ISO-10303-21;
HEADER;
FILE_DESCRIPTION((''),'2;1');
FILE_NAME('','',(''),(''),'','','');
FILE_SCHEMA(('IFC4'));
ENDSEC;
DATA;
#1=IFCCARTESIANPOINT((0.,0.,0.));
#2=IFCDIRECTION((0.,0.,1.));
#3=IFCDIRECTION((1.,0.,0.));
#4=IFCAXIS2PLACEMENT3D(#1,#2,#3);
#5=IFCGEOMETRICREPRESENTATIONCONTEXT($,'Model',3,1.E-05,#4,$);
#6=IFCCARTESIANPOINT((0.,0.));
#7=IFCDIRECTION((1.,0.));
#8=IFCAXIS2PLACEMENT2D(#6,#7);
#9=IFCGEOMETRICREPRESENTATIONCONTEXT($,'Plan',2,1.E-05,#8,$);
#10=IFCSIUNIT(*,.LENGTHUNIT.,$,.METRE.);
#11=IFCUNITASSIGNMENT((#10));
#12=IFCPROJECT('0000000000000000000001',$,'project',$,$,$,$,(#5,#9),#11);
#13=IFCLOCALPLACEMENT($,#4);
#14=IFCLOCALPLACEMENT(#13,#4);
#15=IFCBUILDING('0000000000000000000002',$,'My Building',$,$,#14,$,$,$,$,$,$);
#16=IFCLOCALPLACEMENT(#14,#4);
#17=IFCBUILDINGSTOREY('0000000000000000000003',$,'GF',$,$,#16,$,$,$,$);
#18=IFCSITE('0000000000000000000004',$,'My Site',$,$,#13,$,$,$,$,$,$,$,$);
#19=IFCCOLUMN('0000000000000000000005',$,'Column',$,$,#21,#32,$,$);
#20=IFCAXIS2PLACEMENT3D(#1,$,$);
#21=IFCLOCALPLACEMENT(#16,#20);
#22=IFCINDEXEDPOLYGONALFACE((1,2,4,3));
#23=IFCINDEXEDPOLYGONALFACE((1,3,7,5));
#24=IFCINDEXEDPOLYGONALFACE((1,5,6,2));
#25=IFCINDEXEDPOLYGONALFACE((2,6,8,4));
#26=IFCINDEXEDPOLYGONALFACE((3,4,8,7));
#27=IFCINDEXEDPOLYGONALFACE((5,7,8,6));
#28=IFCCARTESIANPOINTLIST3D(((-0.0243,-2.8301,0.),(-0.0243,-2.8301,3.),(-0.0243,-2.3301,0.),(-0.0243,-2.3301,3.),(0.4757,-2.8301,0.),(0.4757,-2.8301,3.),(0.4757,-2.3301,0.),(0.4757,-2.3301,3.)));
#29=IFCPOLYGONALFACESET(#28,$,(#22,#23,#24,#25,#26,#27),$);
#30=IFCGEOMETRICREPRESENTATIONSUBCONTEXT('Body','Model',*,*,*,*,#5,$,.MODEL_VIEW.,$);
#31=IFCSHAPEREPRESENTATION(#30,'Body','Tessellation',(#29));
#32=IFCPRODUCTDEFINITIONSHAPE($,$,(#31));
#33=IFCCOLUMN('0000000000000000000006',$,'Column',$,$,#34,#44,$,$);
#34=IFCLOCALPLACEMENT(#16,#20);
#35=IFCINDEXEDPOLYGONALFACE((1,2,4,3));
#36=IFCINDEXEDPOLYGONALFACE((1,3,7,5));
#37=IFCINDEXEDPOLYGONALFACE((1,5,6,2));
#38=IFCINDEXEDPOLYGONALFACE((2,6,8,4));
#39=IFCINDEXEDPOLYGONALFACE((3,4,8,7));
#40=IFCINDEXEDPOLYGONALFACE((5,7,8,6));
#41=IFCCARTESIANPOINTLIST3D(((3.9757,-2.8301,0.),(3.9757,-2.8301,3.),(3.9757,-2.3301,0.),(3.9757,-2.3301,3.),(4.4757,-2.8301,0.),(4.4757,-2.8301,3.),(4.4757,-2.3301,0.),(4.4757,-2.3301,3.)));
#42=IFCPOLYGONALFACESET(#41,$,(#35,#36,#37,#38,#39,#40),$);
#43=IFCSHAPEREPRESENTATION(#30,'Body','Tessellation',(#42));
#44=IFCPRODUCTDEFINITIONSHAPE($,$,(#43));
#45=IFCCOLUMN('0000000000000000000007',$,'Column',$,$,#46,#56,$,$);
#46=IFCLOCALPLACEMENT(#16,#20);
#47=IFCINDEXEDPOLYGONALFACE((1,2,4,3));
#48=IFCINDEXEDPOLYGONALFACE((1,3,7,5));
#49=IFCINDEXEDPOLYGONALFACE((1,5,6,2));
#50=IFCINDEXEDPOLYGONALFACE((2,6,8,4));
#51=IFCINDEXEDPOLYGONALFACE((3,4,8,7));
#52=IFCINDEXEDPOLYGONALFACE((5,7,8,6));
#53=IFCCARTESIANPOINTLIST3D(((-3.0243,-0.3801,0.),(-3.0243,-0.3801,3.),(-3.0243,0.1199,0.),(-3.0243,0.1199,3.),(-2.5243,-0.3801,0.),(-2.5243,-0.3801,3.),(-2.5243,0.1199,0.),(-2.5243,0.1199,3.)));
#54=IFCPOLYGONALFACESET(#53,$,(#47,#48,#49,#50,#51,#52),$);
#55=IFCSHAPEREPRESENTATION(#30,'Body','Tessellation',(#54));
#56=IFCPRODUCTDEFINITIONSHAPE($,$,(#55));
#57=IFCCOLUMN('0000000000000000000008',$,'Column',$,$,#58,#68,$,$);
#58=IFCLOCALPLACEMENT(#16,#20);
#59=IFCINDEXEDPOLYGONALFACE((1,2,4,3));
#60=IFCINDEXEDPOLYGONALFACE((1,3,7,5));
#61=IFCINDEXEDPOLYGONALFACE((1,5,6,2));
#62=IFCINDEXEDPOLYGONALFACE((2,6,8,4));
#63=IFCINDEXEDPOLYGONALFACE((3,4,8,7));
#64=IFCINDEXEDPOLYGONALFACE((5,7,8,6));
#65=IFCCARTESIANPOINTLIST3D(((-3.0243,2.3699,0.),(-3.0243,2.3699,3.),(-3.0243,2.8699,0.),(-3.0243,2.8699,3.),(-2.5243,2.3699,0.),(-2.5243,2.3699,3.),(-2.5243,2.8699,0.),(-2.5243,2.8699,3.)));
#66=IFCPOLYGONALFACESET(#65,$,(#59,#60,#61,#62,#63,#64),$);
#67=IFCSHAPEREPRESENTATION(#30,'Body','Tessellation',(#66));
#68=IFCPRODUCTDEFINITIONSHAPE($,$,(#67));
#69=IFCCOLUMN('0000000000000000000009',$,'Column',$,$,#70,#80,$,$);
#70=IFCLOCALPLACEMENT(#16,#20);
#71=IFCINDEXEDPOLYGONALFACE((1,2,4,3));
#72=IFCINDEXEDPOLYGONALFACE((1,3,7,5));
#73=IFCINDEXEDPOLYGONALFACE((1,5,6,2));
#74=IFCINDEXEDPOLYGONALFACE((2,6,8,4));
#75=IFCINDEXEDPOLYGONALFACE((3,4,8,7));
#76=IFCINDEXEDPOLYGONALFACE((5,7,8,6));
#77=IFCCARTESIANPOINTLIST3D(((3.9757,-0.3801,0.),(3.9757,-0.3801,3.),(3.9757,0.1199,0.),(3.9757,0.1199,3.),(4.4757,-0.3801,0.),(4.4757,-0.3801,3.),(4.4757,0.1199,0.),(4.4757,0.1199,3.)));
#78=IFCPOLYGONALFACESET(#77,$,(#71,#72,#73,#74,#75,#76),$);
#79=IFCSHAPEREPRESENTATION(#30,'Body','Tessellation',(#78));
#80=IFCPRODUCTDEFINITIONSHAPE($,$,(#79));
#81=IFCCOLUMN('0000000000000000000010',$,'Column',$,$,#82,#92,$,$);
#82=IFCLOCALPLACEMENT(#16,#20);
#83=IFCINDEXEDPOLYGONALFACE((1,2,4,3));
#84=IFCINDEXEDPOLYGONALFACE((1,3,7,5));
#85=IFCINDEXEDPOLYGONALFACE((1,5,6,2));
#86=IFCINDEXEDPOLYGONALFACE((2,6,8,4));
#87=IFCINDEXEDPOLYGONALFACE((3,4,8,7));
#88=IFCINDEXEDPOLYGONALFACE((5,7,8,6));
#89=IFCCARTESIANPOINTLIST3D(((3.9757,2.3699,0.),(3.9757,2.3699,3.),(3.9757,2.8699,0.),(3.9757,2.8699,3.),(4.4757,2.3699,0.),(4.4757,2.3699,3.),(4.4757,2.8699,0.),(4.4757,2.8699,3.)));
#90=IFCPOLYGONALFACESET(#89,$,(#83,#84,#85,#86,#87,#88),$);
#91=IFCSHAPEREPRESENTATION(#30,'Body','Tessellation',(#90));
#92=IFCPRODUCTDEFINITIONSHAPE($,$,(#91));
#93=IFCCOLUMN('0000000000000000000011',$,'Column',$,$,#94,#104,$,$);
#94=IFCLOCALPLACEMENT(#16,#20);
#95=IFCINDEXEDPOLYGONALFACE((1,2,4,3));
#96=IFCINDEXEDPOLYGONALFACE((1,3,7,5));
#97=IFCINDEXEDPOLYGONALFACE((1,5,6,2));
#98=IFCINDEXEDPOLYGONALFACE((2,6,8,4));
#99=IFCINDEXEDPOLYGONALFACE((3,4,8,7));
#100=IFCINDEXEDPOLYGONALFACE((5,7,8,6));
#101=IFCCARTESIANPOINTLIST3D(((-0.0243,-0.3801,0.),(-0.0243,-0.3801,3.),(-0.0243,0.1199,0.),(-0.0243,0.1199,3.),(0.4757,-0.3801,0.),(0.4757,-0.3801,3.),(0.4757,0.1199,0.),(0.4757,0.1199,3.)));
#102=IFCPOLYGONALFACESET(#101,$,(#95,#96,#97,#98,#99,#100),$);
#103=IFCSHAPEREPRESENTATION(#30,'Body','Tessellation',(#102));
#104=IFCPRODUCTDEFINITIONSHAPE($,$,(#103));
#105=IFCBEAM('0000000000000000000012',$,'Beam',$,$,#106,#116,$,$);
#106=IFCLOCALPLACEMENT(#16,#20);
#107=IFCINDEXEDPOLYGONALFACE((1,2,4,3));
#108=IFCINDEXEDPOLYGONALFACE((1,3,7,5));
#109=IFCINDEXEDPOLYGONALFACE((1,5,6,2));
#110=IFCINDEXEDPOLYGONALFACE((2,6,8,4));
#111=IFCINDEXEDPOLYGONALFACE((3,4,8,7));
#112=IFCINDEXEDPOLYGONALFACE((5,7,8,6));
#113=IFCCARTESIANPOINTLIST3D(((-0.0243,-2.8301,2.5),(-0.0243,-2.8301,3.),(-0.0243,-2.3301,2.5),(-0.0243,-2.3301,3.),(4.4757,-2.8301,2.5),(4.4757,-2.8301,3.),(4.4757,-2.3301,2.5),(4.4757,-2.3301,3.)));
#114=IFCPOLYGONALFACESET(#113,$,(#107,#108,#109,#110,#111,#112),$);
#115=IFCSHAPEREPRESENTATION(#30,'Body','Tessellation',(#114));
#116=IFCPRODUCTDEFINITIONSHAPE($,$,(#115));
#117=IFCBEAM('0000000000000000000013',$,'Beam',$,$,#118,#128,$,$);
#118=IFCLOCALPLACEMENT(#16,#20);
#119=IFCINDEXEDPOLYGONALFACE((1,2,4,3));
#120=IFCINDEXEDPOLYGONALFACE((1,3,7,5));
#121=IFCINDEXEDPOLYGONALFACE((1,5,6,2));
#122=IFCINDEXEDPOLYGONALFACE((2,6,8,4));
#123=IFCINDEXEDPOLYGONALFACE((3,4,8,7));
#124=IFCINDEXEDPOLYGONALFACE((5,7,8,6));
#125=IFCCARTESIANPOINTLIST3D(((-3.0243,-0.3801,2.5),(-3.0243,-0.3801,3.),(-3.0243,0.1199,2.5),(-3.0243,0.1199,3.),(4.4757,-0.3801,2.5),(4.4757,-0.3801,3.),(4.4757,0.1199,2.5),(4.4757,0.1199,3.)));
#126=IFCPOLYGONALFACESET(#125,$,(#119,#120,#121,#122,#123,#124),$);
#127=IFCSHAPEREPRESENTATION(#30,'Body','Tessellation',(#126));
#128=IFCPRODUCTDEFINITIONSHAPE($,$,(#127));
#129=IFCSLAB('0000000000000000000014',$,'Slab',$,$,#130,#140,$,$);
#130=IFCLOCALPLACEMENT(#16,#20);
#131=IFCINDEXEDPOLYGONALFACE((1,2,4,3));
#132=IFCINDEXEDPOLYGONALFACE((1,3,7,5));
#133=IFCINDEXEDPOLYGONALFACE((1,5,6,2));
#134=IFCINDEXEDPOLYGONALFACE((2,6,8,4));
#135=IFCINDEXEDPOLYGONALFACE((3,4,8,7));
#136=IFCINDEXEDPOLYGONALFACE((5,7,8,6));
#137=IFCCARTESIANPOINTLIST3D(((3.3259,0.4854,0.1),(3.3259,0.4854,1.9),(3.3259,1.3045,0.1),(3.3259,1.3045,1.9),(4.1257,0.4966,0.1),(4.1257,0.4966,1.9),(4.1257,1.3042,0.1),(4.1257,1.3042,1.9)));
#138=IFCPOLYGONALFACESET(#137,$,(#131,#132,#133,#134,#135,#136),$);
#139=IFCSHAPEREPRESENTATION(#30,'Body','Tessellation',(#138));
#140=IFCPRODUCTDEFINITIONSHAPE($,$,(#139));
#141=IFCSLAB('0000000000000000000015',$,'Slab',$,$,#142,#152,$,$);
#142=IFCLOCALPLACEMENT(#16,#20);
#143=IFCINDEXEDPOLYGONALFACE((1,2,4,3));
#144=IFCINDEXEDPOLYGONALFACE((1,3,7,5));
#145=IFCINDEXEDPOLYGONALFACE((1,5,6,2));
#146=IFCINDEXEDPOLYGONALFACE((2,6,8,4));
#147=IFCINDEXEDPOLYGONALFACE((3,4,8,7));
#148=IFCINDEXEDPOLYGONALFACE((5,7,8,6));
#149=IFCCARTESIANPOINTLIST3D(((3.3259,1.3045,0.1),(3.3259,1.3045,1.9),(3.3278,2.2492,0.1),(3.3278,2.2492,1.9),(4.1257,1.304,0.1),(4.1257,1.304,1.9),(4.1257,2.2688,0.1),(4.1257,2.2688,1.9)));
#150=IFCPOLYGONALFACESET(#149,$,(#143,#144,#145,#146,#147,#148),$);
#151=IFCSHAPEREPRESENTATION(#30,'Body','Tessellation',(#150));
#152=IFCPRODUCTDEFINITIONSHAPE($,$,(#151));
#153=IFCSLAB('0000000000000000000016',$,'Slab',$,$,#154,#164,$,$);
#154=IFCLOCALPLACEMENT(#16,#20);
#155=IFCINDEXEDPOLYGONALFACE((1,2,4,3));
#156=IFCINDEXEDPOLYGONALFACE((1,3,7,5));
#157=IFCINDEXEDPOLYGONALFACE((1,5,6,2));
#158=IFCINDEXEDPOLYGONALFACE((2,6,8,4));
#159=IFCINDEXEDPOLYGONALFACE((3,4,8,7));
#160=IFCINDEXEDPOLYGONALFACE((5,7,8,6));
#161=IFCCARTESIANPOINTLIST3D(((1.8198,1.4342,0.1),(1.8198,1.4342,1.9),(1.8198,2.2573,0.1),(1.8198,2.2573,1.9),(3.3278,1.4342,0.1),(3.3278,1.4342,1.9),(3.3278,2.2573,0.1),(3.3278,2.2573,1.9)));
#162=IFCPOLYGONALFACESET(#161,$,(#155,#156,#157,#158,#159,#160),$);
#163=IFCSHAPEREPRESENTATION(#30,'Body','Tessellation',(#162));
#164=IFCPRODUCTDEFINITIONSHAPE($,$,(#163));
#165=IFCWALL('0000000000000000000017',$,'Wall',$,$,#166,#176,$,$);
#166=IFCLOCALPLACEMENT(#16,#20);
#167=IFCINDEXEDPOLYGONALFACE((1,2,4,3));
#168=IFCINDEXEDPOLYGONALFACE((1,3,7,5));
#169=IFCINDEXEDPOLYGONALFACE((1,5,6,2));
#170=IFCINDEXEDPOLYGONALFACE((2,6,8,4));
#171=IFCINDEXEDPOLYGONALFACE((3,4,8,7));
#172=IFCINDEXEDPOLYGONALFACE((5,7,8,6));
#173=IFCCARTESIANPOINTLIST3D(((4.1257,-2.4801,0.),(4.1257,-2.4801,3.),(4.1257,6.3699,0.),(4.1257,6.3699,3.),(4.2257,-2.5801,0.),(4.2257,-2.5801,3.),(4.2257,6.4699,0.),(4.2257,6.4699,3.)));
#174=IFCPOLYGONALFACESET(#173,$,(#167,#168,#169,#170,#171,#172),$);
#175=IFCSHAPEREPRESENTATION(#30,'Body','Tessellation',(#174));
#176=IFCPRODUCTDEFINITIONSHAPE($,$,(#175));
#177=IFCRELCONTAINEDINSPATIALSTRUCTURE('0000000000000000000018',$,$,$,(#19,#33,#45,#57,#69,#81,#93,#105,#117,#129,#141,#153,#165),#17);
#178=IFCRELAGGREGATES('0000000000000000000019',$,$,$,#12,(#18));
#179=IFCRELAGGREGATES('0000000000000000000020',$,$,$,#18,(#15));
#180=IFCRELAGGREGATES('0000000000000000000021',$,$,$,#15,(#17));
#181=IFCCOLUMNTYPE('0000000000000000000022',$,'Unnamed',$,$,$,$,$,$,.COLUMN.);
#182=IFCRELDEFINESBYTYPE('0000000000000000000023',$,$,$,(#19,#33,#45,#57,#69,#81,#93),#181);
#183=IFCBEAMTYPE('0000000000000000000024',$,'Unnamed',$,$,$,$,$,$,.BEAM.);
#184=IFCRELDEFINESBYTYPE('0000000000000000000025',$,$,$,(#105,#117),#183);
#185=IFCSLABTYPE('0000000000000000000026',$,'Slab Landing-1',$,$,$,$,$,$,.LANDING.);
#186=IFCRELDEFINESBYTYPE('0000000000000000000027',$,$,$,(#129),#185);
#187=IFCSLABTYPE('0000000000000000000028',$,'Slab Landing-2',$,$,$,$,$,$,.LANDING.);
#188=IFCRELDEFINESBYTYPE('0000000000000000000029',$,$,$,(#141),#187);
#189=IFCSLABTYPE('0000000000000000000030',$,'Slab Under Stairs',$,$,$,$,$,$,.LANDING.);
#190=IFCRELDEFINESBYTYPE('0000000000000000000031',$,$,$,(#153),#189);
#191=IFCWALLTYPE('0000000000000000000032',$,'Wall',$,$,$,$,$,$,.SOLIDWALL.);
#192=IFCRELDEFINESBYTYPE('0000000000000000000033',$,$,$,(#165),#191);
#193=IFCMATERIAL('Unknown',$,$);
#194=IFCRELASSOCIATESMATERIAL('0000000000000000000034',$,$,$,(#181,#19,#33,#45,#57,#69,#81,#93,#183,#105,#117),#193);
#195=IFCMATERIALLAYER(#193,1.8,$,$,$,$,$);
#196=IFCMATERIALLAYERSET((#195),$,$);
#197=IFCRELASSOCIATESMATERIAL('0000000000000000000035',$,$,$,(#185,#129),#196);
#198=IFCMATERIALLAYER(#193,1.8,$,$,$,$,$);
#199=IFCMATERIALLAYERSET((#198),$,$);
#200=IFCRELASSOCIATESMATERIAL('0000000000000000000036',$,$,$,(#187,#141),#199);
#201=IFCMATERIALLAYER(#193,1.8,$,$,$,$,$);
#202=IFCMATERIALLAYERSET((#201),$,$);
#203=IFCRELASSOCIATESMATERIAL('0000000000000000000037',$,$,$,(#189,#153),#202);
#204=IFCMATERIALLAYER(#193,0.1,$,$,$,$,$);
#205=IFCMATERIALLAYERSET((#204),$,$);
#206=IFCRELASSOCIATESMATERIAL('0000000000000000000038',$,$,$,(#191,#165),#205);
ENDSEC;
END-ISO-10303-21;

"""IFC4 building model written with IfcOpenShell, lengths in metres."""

from ifc_helpers import new_model, si_unit, frame, origin_with_axes, origin_2d_with_axis, place, context, subcontext, project, spatial, line, indexed_curve, rectangle, outline, extrude, material, layer, layer_set, layer_usage, material_profile, profile_set, profile_usage, type_object, element, save


model = new_model("IFC4")

# Units and contexts
model_context = context("Model", 3, precision=1e-05, world=origin_with_axes())
plan_context = context("Plan", 2, precision=1e-05, world=origin_2d_with_axis())
body_context_1 = subcontext(model_context, "Body", "Model", "MODEL_VIEW")
ifc_project = project(units=[si_unit("LENGTHUNIT", "METRE")], contexts=[model_context, plan_context])

# Site, building, storey
site_placement = place(None, origin_with_axes())
site = spatial("IfcSite", under=ifc_project, at=site_placement, Name="My Site")
building_placement = place(site_placement, origin_with_axes())
building = spatial("IfcBuilding", under=site, at=building_placement, Name="My Building")
storey_placement = place(building_placement, origin_with_axes())
storey = spatial("IfcBuildingStorey", under=building, at=storey_placement, Name="GF")

# Columns
ifc_material = material(Name="Unknown")
ifc_material_profile_1 = material_profile(ifc_material, rectangle(XDim=0.5, YDim=0.5))
ifc_profile_set_1 = profile_set([ifc_material_profile_1])
ifc_profile_usage_1 = profile_usage(ifc_profile_set_1, cardinal=5)
column_type = type_object("IfcColumnType", Name="Unnamed", PredefinedType="COLUMN", material=ifc_profile_set_1)
column_1_placement = place(storey_placement, frame((0.2257, -2.5801, 0.0), z_axis=(0.0, 0.0, 1.0), x_axis=(1.0, 0.0, 0.0)))
element("IfcColumn", 1, at=column_1_placement, inside=storey, type_object=column_type, material=ifc_profile_usage_1, Name="Column", context=body_context_1, shape_type="SweptSolid", body=[
    extrude(rectangle(XDim=0.5, YDim=0.5), origin_with_axes(), (0.0, 0.0, 1.0), 3.0),
])
ifc_profile_usage_2 = profile_usage(ifc_profile_set_1, cardinal=5)
column_2_placement = place(storey_placement, frame((4.2257, -2.5801, 0.0), z_axis=(0.0, 0.0, 1.0), x_axis=(1.0, 0.0, 0.0)))
element("IfcColumn", 2, at=column_2_placement, inside=storey, type_object=column_type, material=ifc_profile_usage_2, Name="Column", context=body_context_1, shape_type="SweptSolid", body=[
    extrude(rectangle(XDim=0.5, YDim=0.5), origin_with_axes(), (0.0, 0.0, 1.0), 3.0),
])
ifc_profile_usage_3 = profile_usage(ifc_profile_set_1, cardinal=5)
column_3_placement = place(storey_placement, frame((-2.7743, -0.1301, 0.0), z_axis=(0.0, 0.0, 1.0), x_axis=(1.0, 0.0, 0.0)))
element("IfcColumn", 3, at=column_3_placement, inside=storey, type_object=column_type, material=ifc_profile_usage_3, Name="Column", context=body_context_1, shape_type="SweptSolid", body=[
    extrude(rectangle(XDim=0.5, YDim=0.5), origin_with_axes(), (0.0, 0.0, 1.0), 3.0),
])
ifc_profile_usage_4 = profile_usage(ifc_profile_set_1, cardinal=5)
column_4_placement = place(storey_placement, frame((-2.7743, 2.6199, 0.0), z_axis=(0.0, 0.0, 1.0), x_axis=(1.0, 0.0, 0.0)))
element("IfcColumn", 4, at=column_4_placement, inside=storey, type_object=column_type, material=ifc_profile_usage_4, Name="Column", context=body_context_1, shape_type="SweptSolid", body=[
    extrude(rectangle(XDim=0.5, YDim=0.5), origin_with_axes(), (0.0, 0.0, 1.0), 3.0),
])
ifc_profile_usage_5 = profile_usage(ifc_profile_set_1, cardinal=5)
column_5_placement = place(storey_placement, frame((4.2257, -0.1301, 0.0), z_axis=(0.0, 0.0, 1.0), x_axis=(1.0, 0.0, 0.0)))
element("IfcColumn", 5, at=column_5_placement, inside=storey, type_object=column_type, material=ifc_profile_usage_5, Name="Column", context=body_context_1, shape_type="SweptSolid", body=[
    extrude(rectangle(XDim=0.5, YDim=0.5), origin_with_axes(), (0.0, 0.0, 1.0), 3.0),
])
ifc_profile_usage_6 = profile_usage(ifc_profile_set_1, cardinal=5)
column_6_placement = place(storey_placement, frame((4.2257, 2.6199, 0.0), z_axis=(0.0, 0.0, 1.0), x_axis=(1.0, 0.0, 0.0)))
element("IfcColumn", 6, at=column_6_placement, inside=storey, type_object=column_type, material=ifc_profile_usage_6, Name="Column", context=body_context_1, shape_type="SweptSolid", body=[
    extrude(rectangle(XDim=0.5, YDim=0.5), origin_with_axes(), (0.0, 0.0, 1.0), 3.0),
])
ifc_profile_usage_7 = profile_usage(ifc_profile_set_1, cardinal=5)
column_7_placement = place(storey_placement, frame((0.2257, -0.1301, 0.0), z_axis=(0.0, 0.0, 1.0), x_axis=(1.0, 0.0, 0.0)))
element("IfcColumn", 7, at=column_7_placement, inside=storey, type_object=column_type, material=ifc_profile_usage_7, Name="Column", context=body_context_1, shape_type="SweptSolid", body=[
    extrude(rectangle(XDim=0.5, YDim=0.5), origin_with_axes(), (0.0, 0.0, 1.0), 3.0),
])

# Beams
ifc_material_profile_2 = material_profile(ifc_material, rectangle(XDim=0.5, YDim=0.5))
ifc_profile_set_2 = profile_set([ifc_material_profile_2])
ifc_profile_usage_8 = profile_usage(ifc_profile_set_2, cardinal=7)
beam_type = type_object("IfcBeamType", Name="Unnamed", PredefinedType="BEAM", material=ifc_profile_set_2)
beam_1_placement = place(storey_placement, frame((-0.0243, -2.3301, 3.0), z_axis=(1.0, -0.000001, 0.000001), x_axis=(0.000001, 1.0, 0.0)))
element("IfcBeam", 8, at=beam_1_placement, inside=storey, type_object=beam_type, material=ifc_profile_usage_8, Name="Beam", context=body_context_1, shape_type="SweptSolid", body=[
    extrude(rectangle(XDim=0.5, YDim=0.5), frame((-0.25, -0.25, 0.0), z_axis=(0.0, 0.0, 1.0), x_axis=(1.0, 0.0, 0.0)), (0.0, 0.0, 1.0), 4.5),
])
ifc_profile_usage_9 = profile_usage(ifc_profile_set_2, cardinal=7)
beam_2_placement = place(storey_placement, frame((-3.0243, 0.1199, 3.0), z_axis=(1.0, -0.000001, 0.000001), x_axis=(0.000001, 1.0, 0.0)))
element("IfcBeam", 9, at=beam_2_placement, inside=storey, type_object=beam_type, material=ifc_profile_usage_9, Name="Beam", context=body_context_1, shape_type="SweptSolid", body=[
    extrude(rectangle(XDim=0.5, YDim=0.5), frame((-0.25, -0.25, 0.0), z_axis=(0.0, 0.0, 1.0), x_axis=(1.0, 0.0, 0.0)), (0.0, 0.0, 1.0), 7.5),
])

# Slabs
ifc_layer_1 = layer(ifc_material, 1.8)
ifc_layer_set_1 = layer_set([ifc_layer_1])
ifc_layer_usage_1 = layer_usage(ifc_layer_set_1, "AXIS3", "POSITIVE", -0.1)
slab_type_1 = type_object("IfcSlabType", Name="Slab Landing-1", PredefinedType="LANDING", material=ifc_layer_set_1)
slab_1_placement = place(storey_placement, frame((3.3259, 1.3043, 0.2), z_axis=(0.0, 0.0, 1.0), x_axis=(1.0, 0.0, 0.0)))
element("IfcSlab", 10, at=slab_1_placement, inside=storey, type_object=slab_type_1, material=ifc_layer_usage_1, Name="Slab", context=body_context_1, shape_type="SweptSolid", body=[
    extrude(outline(indexed_curve([(0.7998, -0.0001), (0.7998, -0.8077), (0.0, -0.8189), (0.0, 0.0002), (0.7998, -0.0001)])), frame((0.0, 0.0, -0.1), z_axis=(0.0, 0.0, 1.0), x_axis=(1.0, 0.0, 0.0)), (0.0, 0.0, 1.0), 1.8),
])
ifc_layer_2 = layer(ifc_material, 1.8)
ifc_layer_set_2 = layer_set([ifc_layer_2])
ifc_layer_usage_2 = layer_usage(ifc_layer_set_2, "AXIS3", "POSITIVE", -1.8)
slab_type_2 = type_object("IfcSlabType", Name="Slab Landing-2", PredefinedType="LANDING", material=ifc_layer_set_2)
slab_2_placement = place(storey_placement, frame((3.3278, 1.3045, 1.9), z_axis=(0.0, 0.0, 1.0), x_axis=(1.0, 0.0, 0.0)))
element("IfcSlab", 11, at=slab_2_placement, inside=storey, type_object=slab_type_2, material=ifc_layer_usage_2, Name="Slab", context=body_context_1, shape_type="SweptSolid", body=[
    extrude(outline(indexed_curve([(-0.0018, 0.0), (0.0, 0.9447), (0.798, 0.9643), (0.798, -0.0005), (-0.0018, 0.0)])), frame((0.0, 0.0, -1.8), z_axis=(0.0, 0.0, 1.0), x_axis=(1.0, 0.0, 0.0)), (0.0, 0.0, 1.0), 1.8),
])
ifc_layer_3 = layer(ifc_material, 1.8)
ifc_layer_set_3 = layer_set([ifc_layer_3])
ifc_layer_usage_3 = layer_usage(ifc_layer_set_3, "AXIS3", "POSITIVE", -1.8)
slab_type_3 = type_object("IfcSlabType", Name="Slab Under Stairs", PredefinedType="LANDING", material=ifc_layer_set_3)
slab_3_placement = place(storey_placement, frame((3.3278, 2.2573, 1.9), z_axis=(0.0, 0.0, 1.0), x_axis=(1.0, 0.0, 0.0)))
element("IfcSlab", 12, at=slab_3_placement, inside=storey, type_object=slab_type_3, material=ifc_layer_usage_3, Name="Slab", context=body_context_1, shape_type="SweptSolid", body=[
    extrude(outline(indexed_curve([(0.0, 0.0), (0.0, -0.8231), (-1.5079, -0.8231), (-1.5079, 0.0), (0.0, 0.0)])), frame((0.0, 0.0, -1.8), z_axis=(0.0, 0.0, 1.0), x_axis=(1.0, 0.0, 0.0)), (0.0, 0.0, 1.0), 1.8),
])

# Shared definitions
ifc_layer_4 = layer(ifc_material, 0.1)
ifc_layer_set_4 = layer_set([ifc_layer_4])
wall_type = type_object("IfcWallType", Name="Wall", PredefinedType="SOLIDWALL", material=ifc_layer_set_4)

# Wall
ifc_layer_usage_4 = layer_usage(ifc_layer_set_4, "AXIS2", "POSITIVE", 0.0)
wall_1_placement = place(storey_placement, frame((4.2257, -2.5801, 0.0), z_axis=(0.0, 0.0, 1.0), x_axis=(0.0, 1.0, 0.0)))
element("IfcWall", 13, at=wall_1_placement, inside=storey, type_object=wall_type, material=ifc_layer_usage_4, Name="Wall", context=body_context_1, shape_type="SweptSolid", body=[
    extrude(outline(indexed_curve([(0.0, 0.0), (0.1, 0.1), (8.95, 0.1), (9.05, 0.0)], segments=[line(1, 2, 3, 4, 1)])), origin_with_axes(), (0.0, 0.0, 1.0), 3.0),
])

save(model, "model.ifc")
